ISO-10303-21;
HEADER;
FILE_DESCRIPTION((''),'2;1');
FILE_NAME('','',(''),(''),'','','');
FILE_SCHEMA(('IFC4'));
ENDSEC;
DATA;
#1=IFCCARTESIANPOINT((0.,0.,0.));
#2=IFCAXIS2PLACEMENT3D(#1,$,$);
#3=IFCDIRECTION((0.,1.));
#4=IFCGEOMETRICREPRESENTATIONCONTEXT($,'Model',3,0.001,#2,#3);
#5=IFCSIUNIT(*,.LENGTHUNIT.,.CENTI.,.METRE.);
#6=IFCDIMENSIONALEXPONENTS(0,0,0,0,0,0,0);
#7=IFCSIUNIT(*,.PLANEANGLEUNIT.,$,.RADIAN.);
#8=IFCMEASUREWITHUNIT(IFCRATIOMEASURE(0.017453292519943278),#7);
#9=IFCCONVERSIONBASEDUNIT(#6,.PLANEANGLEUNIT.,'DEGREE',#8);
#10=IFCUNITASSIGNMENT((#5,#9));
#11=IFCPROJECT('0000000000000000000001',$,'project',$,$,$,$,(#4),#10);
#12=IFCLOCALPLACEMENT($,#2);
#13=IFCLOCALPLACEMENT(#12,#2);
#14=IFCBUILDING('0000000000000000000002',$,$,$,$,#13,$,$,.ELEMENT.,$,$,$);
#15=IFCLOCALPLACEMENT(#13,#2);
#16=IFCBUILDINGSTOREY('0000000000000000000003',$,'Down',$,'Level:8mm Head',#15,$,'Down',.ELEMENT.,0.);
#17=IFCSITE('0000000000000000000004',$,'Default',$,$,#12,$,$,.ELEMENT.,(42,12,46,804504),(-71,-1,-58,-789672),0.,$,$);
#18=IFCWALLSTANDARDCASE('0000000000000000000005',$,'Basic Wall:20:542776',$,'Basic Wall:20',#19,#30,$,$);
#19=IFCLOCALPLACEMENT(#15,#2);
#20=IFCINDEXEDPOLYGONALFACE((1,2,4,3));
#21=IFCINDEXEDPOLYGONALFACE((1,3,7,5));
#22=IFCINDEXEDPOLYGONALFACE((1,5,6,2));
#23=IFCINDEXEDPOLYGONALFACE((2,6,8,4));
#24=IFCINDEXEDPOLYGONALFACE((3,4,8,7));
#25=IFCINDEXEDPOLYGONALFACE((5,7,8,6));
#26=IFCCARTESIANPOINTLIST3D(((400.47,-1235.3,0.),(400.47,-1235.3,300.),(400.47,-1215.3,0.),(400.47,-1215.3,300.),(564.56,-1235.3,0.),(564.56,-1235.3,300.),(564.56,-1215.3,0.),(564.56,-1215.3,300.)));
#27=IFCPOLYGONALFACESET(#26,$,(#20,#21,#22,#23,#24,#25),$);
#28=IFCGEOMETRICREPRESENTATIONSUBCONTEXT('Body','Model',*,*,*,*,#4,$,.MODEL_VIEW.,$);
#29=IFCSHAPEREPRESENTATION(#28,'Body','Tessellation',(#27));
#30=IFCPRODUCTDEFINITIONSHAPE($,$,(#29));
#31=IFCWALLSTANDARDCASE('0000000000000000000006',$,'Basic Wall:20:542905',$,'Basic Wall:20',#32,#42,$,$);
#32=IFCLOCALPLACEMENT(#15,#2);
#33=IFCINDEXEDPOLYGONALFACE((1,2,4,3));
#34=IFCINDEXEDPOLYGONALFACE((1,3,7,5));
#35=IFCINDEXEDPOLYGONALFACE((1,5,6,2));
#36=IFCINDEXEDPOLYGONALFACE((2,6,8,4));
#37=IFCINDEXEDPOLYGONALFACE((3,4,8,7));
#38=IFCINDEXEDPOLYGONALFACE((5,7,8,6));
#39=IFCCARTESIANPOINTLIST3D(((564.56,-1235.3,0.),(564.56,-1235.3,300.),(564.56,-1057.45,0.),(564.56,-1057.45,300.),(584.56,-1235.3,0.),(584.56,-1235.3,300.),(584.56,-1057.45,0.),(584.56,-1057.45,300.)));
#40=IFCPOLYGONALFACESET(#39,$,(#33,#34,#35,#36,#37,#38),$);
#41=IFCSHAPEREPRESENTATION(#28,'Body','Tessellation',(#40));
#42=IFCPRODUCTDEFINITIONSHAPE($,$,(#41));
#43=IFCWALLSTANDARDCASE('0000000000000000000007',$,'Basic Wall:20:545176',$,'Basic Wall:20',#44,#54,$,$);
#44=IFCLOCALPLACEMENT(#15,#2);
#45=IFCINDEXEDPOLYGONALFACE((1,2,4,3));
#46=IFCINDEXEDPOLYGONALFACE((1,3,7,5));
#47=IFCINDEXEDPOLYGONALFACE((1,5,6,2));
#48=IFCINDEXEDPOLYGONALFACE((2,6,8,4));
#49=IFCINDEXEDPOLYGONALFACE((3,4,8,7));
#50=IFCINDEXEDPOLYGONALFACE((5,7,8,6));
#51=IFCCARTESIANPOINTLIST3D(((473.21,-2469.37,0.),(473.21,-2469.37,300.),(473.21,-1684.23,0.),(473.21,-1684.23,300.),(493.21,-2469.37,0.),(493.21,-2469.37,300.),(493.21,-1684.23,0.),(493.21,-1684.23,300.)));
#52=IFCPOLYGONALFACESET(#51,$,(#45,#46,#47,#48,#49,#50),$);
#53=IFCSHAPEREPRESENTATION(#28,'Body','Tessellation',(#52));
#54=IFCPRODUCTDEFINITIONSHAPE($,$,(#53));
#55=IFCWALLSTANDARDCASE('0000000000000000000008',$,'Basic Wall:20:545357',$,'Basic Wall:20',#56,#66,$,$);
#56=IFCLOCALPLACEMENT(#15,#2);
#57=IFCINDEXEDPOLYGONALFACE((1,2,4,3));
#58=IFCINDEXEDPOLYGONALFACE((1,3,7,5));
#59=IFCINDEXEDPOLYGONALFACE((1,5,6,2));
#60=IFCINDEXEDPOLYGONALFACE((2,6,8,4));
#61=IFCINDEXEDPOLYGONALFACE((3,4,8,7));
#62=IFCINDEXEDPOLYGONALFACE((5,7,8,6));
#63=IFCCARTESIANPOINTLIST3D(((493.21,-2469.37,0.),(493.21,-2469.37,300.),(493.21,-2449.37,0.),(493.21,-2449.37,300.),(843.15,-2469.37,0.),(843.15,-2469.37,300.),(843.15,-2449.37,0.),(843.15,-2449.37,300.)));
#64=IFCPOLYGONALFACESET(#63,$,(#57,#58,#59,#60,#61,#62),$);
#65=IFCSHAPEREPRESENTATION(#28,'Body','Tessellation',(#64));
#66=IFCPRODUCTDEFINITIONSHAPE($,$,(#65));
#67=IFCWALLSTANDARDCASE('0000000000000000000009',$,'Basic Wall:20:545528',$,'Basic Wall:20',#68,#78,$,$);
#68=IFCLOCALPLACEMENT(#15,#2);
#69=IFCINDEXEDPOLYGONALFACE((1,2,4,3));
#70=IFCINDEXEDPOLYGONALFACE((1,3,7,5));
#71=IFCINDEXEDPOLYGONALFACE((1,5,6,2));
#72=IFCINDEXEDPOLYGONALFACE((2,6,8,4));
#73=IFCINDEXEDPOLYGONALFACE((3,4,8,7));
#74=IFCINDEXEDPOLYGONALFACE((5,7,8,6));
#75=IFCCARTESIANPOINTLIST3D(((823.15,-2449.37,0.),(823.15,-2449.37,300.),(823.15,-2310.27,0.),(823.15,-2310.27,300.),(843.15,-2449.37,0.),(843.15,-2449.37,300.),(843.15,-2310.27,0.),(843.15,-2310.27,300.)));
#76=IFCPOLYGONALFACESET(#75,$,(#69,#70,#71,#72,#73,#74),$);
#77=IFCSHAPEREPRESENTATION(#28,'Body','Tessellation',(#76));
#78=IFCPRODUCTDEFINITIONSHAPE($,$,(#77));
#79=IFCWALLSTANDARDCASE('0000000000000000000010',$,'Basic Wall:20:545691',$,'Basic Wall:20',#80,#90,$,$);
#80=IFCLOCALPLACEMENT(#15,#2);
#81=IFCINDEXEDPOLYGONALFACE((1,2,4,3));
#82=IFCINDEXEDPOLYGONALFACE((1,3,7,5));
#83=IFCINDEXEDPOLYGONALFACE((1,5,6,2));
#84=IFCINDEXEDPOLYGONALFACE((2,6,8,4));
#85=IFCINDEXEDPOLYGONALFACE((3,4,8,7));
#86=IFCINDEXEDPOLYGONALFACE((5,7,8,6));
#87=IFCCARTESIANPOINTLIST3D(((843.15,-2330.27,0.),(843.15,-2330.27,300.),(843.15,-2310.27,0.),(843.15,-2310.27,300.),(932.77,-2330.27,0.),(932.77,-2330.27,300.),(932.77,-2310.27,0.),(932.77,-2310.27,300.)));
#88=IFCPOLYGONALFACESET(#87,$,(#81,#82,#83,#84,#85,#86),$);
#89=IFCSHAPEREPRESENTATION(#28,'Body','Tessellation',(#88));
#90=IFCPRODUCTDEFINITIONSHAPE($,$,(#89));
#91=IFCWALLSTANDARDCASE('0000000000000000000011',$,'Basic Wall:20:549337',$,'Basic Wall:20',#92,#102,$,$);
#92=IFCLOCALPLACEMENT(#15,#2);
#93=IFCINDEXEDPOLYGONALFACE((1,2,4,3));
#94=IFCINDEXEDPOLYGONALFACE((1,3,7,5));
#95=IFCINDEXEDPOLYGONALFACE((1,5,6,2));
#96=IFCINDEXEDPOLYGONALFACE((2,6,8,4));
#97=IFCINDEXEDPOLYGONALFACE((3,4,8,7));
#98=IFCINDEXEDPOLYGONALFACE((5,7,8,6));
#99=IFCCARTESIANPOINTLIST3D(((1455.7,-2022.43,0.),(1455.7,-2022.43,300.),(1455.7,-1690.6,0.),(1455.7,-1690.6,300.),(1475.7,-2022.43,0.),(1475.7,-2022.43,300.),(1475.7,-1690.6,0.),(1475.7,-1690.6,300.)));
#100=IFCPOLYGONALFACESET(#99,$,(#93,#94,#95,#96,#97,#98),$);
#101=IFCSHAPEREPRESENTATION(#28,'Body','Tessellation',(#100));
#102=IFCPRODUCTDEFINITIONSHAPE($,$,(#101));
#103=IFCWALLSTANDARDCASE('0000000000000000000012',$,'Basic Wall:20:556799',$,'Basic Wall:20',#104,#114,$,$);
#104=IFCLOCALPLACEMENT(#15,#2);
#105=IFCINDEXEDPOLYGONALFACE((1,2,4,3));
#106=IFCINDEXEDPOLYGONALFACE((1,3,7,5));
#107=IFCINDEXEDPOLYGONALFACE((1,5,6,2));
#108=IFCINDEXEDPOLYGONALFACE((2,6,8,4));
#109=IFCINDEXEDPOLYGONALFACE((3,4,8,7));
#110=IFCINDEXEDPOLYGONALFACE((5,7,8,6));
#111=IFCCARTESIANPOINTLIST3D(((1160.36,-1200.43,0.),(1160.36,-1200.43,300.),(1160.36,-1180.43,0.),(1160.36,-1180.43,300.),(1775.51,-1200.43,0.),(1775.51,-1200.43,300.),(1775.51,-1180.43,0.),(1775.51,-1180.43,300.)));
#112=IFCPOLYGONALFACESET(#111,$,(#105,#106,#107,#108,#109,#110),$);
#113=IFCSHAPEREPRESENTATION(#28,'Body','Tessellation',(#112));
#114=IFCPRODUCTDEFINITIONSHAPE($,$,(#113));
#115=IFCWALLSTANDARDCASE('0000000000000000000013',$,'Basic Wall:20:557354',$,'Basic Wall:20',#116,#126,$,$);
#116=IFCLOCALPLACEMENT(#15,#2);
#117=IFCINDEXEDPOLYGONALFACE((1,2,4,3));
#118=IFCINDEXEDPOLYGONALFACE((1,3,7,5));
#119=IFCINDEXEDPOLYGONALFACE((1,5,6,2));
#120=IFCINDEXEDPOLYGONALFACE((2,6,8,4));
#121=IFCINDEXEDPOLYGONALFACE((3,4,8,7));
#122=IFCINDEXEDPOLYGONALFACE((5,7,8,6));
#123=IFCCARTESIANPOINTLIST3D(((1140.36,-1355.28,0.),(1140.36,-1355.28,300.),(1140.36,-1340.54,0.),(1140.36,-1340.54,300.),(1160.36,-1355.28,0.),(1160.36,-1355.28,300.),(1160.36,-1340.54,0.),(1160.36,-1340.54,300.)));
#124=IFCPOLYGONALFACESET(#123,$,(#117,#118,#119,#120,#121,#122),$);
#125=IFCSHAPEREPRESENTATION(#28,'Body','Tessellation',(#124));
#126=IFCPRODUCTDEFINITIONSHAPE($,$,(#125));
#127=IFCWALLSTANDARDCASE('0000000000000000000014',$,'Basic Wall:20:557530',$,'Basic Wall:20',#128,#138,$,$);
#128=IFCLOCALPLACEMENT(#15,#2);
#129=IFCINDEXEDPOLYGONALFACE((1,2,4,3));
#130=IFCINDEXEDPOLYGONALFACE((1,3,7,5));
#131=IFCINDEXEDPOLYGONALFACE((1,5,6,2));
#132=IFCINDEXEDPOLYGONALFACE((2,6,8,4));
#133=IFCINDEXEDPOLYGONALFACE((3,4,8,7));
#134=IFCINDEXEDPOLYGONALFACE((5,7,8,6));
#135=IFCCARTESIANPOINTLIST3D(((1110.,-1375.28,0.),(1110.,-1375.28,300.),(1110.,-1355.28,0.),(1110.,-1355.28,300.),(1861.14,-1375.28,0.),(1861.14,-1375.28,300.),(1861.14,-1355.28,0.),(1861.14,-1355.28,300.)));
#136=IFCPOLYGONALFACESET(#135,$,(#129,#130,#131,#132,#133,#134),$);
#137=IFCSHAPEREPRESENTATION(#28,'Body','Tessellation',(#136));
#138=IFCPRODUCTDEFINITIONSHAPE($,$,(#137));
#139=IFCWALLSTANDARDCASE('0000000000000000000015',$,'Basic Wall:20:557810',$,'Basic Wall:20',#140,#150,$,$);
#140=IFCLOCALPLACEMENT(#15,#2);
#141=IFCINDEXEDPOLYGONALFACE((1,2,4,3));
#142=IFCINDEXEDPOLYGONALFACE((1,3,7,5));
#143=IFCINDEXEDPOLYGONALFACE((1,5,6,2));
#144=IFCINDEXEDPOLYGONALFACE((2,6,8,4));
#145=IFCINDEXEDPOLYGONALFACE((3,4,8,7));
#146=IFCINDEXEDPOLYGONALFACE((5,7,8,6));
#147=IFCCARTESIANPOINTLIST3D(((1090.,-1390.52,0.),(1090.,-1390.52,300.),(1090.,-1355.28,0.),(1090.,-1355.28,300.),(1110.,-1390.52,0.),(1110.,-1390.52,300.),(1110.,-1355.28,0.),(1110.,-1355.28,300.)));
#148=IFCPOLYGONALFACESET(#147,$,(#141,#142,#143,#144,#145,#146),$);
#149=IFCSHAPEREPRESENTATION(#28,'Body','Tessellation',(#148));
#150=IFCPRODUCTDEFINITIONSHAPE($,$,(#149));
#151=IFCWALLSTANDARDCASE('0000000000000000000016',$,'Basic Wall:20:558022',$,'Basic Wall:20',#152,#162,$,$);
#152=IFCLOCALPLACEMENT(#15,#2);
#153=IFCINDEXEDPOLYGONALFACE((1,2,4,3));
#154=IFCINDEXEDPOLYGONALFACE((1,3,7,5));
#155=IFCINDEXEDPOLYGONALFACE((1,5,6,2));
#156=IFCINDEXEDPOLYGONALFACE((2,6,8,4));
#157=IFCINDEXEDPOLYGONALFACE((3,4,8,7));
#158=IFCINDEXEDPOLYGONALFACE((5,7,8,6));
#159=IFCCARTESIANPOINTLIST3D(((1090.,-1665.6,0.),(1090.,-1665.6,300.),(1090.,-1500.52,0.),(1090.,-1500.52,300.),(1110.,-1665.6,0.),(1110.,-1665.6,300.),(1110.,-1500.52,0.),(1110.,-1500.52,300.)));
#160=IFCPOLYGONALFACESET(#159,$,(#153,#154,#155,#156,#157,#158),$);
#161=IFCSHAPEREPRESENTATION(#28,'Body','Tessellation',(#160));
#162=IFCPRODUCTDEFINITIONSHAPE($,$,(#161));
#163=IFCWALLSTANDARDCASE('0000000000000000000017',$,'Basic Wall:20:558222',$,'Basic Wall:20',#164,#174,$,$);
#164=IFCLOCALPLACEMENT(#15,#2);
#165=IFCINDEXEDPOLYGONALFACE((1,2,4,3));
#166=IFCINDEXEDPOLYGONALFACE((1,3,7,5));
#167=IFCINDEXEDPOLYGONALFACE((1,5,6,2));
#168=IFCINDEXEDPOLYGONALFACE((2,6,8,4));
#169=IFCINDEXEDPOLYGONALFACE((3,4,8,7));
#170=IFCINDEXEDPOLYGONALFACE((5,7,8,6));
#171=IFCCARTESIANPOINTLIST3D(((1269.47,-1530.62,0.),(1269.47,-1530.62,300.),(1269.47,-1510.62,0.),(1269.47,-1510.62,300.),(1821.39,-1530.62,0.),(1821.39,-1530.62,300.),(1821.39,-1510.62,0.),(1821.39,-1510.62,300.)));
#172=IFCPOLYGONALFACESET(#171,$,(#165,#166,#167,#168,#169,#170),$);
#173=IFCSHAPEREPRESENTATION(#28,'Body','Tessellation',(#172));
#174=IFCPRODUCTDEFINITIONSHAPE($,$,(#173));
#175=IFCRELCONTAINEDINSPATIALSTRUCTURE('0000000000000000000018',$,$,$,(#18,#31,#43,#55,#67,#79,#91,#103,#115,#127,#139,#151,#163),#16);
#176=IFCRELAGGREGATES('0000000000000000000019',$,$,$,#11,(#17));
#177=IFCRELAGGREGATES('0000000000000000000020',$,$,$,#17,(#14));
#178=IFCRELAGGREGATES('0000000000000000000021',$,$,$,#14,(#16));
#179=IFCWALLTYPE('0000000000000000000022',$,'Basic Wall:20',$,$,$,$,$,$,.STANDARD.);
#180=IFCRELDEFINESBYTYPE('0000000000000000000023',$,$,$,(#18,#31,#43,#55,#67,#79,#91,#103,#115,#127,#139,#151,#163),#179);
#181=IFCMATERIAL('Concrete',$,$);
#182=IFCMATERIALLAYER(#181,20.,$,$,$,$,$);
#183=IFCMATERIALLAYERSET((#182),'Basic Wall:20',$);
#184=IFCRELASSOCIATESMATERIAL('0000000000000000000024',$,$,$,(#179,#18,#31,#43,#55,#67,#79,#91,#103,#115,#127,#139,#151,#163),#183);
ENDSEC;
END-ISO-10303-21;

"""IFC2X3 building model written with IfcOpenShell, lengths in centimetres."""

from ifc_helpers import new_model, entity, si_unit, converted_unit, direction, frame, frame_2d, origin, place, context, subcontext, project, spatial, rectangle, extrude, material, layer, layer_set, layer_usage, type_object, element, save


model = new_model("IFC2X3")

# Units and contexts
model_context = context("Model", 3, precision=0.001, world=origin(), true_north=direction((0.0, 1.0)))
body_context = subcontext(model_context, "Body", "Model", "MODEL_VIEW")
ifc_project = project(units=[si_unit("LENGTHUNIT", "METRE", prefix="CENTI"), converted_unit("PLANEANGLEUNIT", "DEGREE", entity("IfcRatioMeasure", 0.017453292519943278), si_unit("PLANEANGLEUNIT", "RADIAN"), dimensions=[0, 0, 0, 0, 0, 0, 0])], contexts=[model_context])

# Site, building, storey
site_placement = place(None, origin())
site = spatial("IfcSite", under=ifc_project, at=site_placement, Name="Default", CompositionType="ELEMENT", RefLatitude=(42, 12, 46, 804504), RefLongitude=(-71, -1, -58, -789672), RefElevation=0.0)
building_placement = place(site_placement, origin())
building = spatial("IfcBuilding", under=site, at=building_placement, CompositionType="ELEMENT")
storey_placement = place(building_placement, origin())
storey = spatial("IfcBuildingStorey", under=building, at=storey_placement, Name="Down", ObjectType="Level:8mm Head", LongName="Down", CompositionType="ELEMENT", Elevation=0.0)

# Walls
ifc_material = material(Name="Concrete")
ifc_layer_1 = layer(ifc_material, 20.0)
ifc_layer_set_1 = layer_set([ifc_layer_1], Name="Basic Wall:20")
ifc_layer_usage_1 = layer_usage(ifc_layer_set_1, "AXIS2", "NEGATIVE", 10.0)
wall_type_1 = type_object("IfcWallType", Name="Basic Wall:20", PredefinedType="STANDARD", material=ifc_layer_set_1)
wall_1_placement = place(storey_placement, frame((400.47, -1225.3, 0.0)))
element("IfcWallStandardCase", 1, at=wall_1_placement, inside=storey, type_object=wall_type_1, material=ifc_layer_usage_1, Name="Basic Wall:20:542776", ObjectType="Basic Wall:20", context=body_context, shape_type="SweptSolid", body=[
    extrude(rectangle(XDim=164.09, YDim=20.0, at=frame_2d((82.04, 0.0), x_axis=(-1.0, 0.0))), origin(), (0.0, 0.0, 1.0), 300.0),
])
ifc_layer_usage_2 = layer_usage(ifc_layer_set_1, "AXIS2", "POSITIVE", -10.0)
wall_2_placement = place(storey_placement, frame((574.56, -1235.3, 0.0), z_axis=(0.0, 0.0, 1.0), x_axis=(0.0, 1.0, 0.0)))
element("IfcWallStandardCase", 2, at=wall_2_placement, inside=storey, type_object=wall_type_1, material=ifc_layer_usage_2, Name="Basic Wall:20:542905", ObjectType="Basic Wall:20", context=body_context, shape_type="SweptSolid", body=[
    extrude(rectangle(XDim=177.85, YDim=20.0, at=frame_2d((88.92, 0.0), x_axis=(-1.0, 0.0))), origin(), (0.0, 0.0, 1.0), 300.0),
])
ifc_layer_usage_3 = layer_usage(ifc_layer_set_1, "AXIS2", "NEGATIVE", 10.0)
wall_3_placement = place(storey_placement, frame((483.21, -1684.23, 0.0), z_axis=(0.0, 0.0, 1.0), x_axis=(0.0, -1.0, 0.0)))
element("IfcWallStandardCase", 3, at=wall_3_placement, inside=storey, type_object=wall_type_1, material=ifc_layer_usage_3, Name="Basic Wall:20:545176", ObjectType="Basic Wall:20", context=body_context, shape_type="SweptSolid", body=[
    extrude(rectangle(XDim=785.14, YDim=20.0, at=frame_2d((392.57, 0.0), x_axis=(-1.0, 0.0))), origin(), (0.0, 0.0, 1.0), 300.0),
])
ifc_layer_usage_4 = layer_usage(ifc_layer_set_1, "AXIS2", "POSITIVE", -10.0)
wall_4_placement = place(storey_placement, frame((493.21, -2459.37, 0.0)))
element("IfcWallStandardCase", 4, at=wall_4_placement, inside=storey, type_object=wall_type_1, material=ifc_layer_usage_4, Name="Basic Wall:20:545357", ObjectType="Basic Wall:20", context=body_context, shape_type="SweptSolid", body=[
    extrude(rectangle(XDim=349.94, YDim=20.0, at=frame_2d((174.97, 0.0), x_axis=(-1.0, 0.0))), origin(), (0.0, 0.0, 1.0), 300.0),
])
ifc_layer_usage_5 = layer_usage(ifc_layer_set_1, "AXIS2", "POSITIVE", -10.0)
wall_5_placement = place(storey_placement, frame((833.15, -2449.37, 0.0), z_axis=(0.0, 0.0, 1.0), x_axis=(0.0, 1.0, 0.0)))
element("IfcWallStandardCase", 5, at=wall_5_placement, inside=storey, type_object=wall_type_1, material=ifc_layer_usage_5, Name="Basic Wall:20:545528", ObjectType="Basic Wall:20", context=body_context, shape_type="SweptSolid", body=[
    extrude(rectangle(XDim=139.1, YDim=20.0, at=frame_2d((69.55, 0.0), x_axis=(-1.0, 0.0))), origin(), (0.0, 0.0, 1.0), 300.0),
])
ifc_layer_usage_6 = layer_usage(ifc_layer_set_1, "AXIS2", "NEGATIVE", 10.0)
wall_6_placement = place(storey_placement, frame((843.15, -2320.27, 0.0)))
element("IfcWallStandardCase", 6, at=wall_6_placement, inside=storey, type_object=wall_type_1, material=ifc_layer_usage_6, Name="Basic Wall:20:545691", ObjectType="Basic Wall:20", context=body_context, shape_type="SweptSolid", body=[
    extrude(rectangle(XDim=89.62, YDim=20.0, at=frame_2d((44.81, 0.0), x_axis=(-1.0, 0.0))), origin(), (0.0, 0.0, 1.0), 300.0),
])
ifc_layer_usage_7 = layer_usage(ifc_layer_set_1, "AXIS2", "NEGATIVE", 10.0)
wall_7_placement = place(storey_placement, frame((1465.7, -2022.43, 0.0), z_axis=(0.0, 0.0, 1.0), x_axis=(0.0, 1.0, 0.0)))
element("IfcWallStandardCase", 7, at=wall_7_placement, inside=storey, type_object=wall_type_1, material=ifc_layer_usage_7, Name="Basic Wall:20:549337", ObjectType="Basic Wall:20", context=body_context, shape_type="SweptSolid", body=[
    extrude(rectangle(XDim=331.83, YDim=20.0, at=frame_2d((165.91, 0.0), x_axis=(-1.0, 0.0))), origin(), (0.0, 0.0, 1.0), 300.0),
])
ifc_layer_usage_8 = layer_usage(ifc_layer_set_1, "AXIS2", "POSITIVE", -10.0)
wall_8_placement = place(storey_placement, frame((1160.36, -1190.43, 0.0)))
element("IfcWallStandardCase", 8, at=wall_8_placement, inside=storey, type_object=wall_type_1, material=ifc_layer_usage_8, Name="Basic Wall:20:556799", ObjectType="Basic Wall:20", context=body_context, shape_type="SweptSolid", body=[
    extrude(rectangle(XDim=615.16, YDim=20.0, at=frame_2d((307.58, 0.0), x_axis=(-1.0, 0.0))), origin(), (0.0, 0.0, 1.0), 300.0),
])
ifc_layer_usage_9 = layer_usage(ifc_layer_set_1, "AXIS2", "POSITIVE", -10.0)
wall_9_placement = place(storey_placement, frame((1150.36, -1340.54, 0.0), z_axis=(0.0, 0.0, 1.0), x_axis=(0.0, -1.0, 0.0)))
element("IfcWallStandardCase", 9, at=wall_9_placement, inside=storey, type_object=wall_type_1, material=ifc_layer_usage_9, Name="Basic Wall:20:557354", ObjectType="Basic Wall:20", context=body_context, shape_type="SweptSolid", body=[
    extrude(rectangle(XDim=14.74, YDim=20.0, at=frame_2d((7.37, 0.0), x_axis=(-1.0, 0.0))), origin(), (0.0, 0.0, 1.0), 300.0),
])
ifc_layer_usage_10 = layer_usage(ifc_layer_set_1, "AXIS2", "POSITIVE", -10.0)
wall_10_placement = place(storey_placement, frame((1110.0, -1365.28, 0.0)))
element("IfcWallStandardCase", 10, at=wall_10_placement, inside=storey, type_object=wall_type_1, material=ifc_layer_usage_10, Name="Basic Wall:20:557530", ObjectType="Basic Wall:20", context=body_context, shape_type="SweptSolid", body=[
    extrude(rectangle(XDim=751.13, YDim=20.0, at=frame_2d((375.57, 0.0), x_axis=(-1.0, 0.0))), origin(), (0.0, 0.0, 1.0), 300.0),
])
ifc_layer_usage_11 = layer_usage(ifc_layer_set_1, "AXIS2", "POSITIVE", -10.0)
wall_11_placement = place(storey_placement, frame((1100.0, -1355.28, 0.0), z_axis=(0.0, 0.0, 1.0), x_axis=(0.0, -1.0, 0.0)))
element("IfcWallStandardCase", 11, at=wall_11_placement, inside=storey, type_object=wall_type_1, material=ifc_layer_usage_11, Name="Basic Wall:20:557810", ObjectType="Basic Wall:20", context=body_context, shape_type="SweptSolid", body=[
    extrude(rectangle(XDim=35.24, YDim=20.0, at=frame_2d((17.62, 0.0), x_axis=(-1.0, 0.0))), origin(), (0.0, 0.0, 1.0), 300.0),
])
ifc_layer_usage_12 = layer_usage(ifc_layer_set_1, "AXIS2", "POSITIVE", -10.0)
wall_12_placement = place(storey_placement, frame((1100.0, -1500.52, 0.0), z_axis=(0.0, 0.0, 1.0), x_axis=(0.0, -1.0, 0.0)))
element("IfcWallStandardCase", 12, at=wall_12_placement, inside=storey, type_object=wall_type_1, material=ifc_layer_usage_12, Name="Basic Wall:20:558022", ObjectType="Basic Wall:20", context=body_context, shape_type="SweptSolid", body=[
    extrude(rectangle(XDim=165.09, YDim=20.0, at=frame_2d((82.54, 0.0), x_axis=(-1.0, 0.0))), origin(), (0.0, 0.0, 1.0), 300.0),
])
ifc_layer_usage_13 = layer_usage(ifc_layer_set_1, "AXIS2", "POSITIVE", -10.0)
wall_13_placement = place(storey_placement, frame((1269.47, -1520.62, 0.0)))
element("IfcWallStandardCase", 13, at=wall_13_placement, inside=storey, type_object=wall_type_1, material=ifc_layer_usage_13, Name="Basic Wall:20:558222", ObjectType="Basic Wall:20", context=body_context, shape_type="SweptSolid", body=[
    extrude(rectangle(XDim=551.91, YDim=20.0, at=frame_2d((275.96, 0.0), x_axis=(-1.0, 0.0))), origin(), (0.0, 0.0, 1.0), 300.0),
])

save(model, "model.ifc")
